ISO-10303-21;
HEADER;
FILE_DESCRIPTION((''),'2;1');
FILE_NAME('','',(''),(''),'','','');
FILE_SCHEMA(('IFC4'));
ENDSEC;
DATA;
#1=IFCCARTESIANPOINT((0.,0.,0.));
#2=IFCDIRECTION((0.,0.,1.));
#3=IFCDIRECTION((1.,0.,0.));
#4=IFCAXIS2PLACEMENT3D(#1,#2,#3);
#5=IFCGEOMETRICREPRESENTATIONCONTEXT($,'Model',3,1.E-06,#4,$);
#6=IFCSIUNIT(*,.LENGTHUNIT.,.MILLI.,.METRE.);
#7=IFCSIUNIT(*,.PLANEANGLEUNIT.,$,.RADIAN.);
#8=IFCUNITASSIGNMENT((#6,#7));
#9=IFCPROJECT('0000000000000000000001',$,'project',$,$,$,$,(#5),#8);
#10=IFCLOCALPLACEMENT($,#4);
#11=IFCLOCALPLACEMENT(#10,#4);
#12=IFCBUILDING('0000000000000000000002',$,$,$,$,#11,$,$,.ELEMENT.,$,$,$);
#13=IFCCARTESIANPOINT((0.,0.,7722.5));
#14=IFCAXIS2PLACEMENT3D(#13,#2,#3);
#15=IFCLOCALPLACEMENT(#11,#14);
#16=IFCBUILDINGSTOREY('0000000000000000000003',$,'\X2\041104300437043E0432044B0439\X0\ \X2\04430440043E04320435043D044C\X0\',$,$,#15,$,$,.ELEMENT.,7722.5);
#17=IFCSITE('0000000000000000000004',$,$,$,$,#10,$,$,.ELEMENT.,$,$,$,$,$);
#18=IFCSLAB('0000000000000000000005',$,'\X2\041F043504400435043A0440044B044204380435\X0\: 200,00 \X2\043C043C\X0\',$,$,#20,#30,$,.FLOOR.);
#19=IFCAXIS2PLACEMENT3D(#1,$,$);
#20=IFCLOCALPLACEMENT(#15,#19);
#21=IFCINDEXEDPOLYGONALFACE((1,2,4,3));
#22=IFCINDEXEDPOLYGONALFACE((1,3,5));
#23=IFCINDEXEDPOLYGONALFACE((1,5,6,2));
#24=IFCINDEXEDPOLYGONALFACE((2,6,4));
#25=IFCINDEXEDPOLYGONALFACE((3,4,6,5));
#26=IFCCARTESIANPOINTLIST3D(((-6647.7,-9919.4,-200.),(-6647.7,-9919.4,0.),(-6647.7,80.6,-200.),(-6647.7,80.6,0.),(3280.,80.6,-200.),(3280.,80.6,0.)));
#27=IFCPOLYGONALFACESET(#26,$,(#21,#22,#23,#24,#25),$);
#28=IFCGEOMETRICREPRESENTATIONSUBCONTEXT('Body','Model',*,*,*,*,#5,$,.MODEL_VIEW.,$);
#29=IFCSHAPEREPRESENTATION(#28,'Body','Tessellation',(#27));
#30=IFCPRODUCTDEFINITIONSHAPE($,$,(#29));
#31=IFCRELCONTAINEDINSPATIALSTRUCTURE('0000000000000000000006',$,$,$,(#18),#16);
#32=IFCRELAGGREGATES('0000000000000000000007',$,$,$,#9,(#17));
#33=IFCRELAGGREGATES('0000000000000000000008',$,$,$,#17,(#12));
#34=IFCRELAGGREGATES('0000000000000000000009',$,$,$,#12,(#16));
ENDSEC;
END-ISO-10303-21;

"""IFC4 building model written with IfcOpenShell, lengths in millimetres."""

from ifc_helpers import new_model, si_unit, frame, origin_with_axes, place, context, subcontext, project, spatial, line, indexed_curve, outline, extrude, source, transform, mapped, element, save


model = new_model("IFC4")

# Units and contexts
model_context = context("Model", 3, precision=1e-06, world=origin_with_axes())
body_context = subcontext(model_context, "Body", "Model", "MODEL_VIEW")
ifc_project = project(units=[si_unit("LENGTHUNIT", "METRE", prefix="MILLI"), si_unit("PLANEANGLEUNIT", "RADIAN")], contexts=[model_context])

# Site, building, storey
site_placement = place(None, origin_with_axes())
site = spatial("IfcSite", under=ifc_project, at=site_placement, CompositionType="ELEMENT")
building_placement = place(site_placement, origin_with_axes())
building = spatial("IfcBuilding", under=site, at=building_placement, CompositionType="ELEMENT")
storey_placement = place(building_placement, frame((0.0, 0.0, 7722.5), z_axis=(0.0, 0.0, 1.0), x_axis=(1.0, 0.0, 0.0)))
storey = spatial("IfcBuildingStorey", under=building, at=storey_placement, Name="Базовый уровень", CompositionType="ELEMENT", Elevation=7722.5)

# Slab
shared_shape = source(origin_with_axes(), body_context, "Body", "SweptSolid", [
    extrude(outline(indexed_curve([(0.0, 0.0), (10000.0, 0.0), (10000.0, -9927.7)], segments=[line(1, 2), line(2, 3), line(3, 1)])), origin_with_axes(), (0.0, 0.0, 1.0), 200.0),
])
slab_placement = place(storey_placement, frame((-6647.7, -9919.4, -200.0), z_axis=(0.0, 0.0, 1.0), x_axis=(0.0, 1.0, 0.0)))
element("IfcSlab", 1, at=slab_placement, inside=storey, Name="Перекрытие: 200,00 мм", PredefinedType="FLOOR", context=body_context, shape_type="MappedRepresentation", body=[
    mapped(shared_shape, transform((0.0, 0.0, 0.0), x_axis=(1.0, 0.0, 0.0), y_axis=(0.0, 1.0, 0.0), z_axis=(0.0, 0.0, 1.0), scale=1.0)),
])

save(model, "model.ifc")
